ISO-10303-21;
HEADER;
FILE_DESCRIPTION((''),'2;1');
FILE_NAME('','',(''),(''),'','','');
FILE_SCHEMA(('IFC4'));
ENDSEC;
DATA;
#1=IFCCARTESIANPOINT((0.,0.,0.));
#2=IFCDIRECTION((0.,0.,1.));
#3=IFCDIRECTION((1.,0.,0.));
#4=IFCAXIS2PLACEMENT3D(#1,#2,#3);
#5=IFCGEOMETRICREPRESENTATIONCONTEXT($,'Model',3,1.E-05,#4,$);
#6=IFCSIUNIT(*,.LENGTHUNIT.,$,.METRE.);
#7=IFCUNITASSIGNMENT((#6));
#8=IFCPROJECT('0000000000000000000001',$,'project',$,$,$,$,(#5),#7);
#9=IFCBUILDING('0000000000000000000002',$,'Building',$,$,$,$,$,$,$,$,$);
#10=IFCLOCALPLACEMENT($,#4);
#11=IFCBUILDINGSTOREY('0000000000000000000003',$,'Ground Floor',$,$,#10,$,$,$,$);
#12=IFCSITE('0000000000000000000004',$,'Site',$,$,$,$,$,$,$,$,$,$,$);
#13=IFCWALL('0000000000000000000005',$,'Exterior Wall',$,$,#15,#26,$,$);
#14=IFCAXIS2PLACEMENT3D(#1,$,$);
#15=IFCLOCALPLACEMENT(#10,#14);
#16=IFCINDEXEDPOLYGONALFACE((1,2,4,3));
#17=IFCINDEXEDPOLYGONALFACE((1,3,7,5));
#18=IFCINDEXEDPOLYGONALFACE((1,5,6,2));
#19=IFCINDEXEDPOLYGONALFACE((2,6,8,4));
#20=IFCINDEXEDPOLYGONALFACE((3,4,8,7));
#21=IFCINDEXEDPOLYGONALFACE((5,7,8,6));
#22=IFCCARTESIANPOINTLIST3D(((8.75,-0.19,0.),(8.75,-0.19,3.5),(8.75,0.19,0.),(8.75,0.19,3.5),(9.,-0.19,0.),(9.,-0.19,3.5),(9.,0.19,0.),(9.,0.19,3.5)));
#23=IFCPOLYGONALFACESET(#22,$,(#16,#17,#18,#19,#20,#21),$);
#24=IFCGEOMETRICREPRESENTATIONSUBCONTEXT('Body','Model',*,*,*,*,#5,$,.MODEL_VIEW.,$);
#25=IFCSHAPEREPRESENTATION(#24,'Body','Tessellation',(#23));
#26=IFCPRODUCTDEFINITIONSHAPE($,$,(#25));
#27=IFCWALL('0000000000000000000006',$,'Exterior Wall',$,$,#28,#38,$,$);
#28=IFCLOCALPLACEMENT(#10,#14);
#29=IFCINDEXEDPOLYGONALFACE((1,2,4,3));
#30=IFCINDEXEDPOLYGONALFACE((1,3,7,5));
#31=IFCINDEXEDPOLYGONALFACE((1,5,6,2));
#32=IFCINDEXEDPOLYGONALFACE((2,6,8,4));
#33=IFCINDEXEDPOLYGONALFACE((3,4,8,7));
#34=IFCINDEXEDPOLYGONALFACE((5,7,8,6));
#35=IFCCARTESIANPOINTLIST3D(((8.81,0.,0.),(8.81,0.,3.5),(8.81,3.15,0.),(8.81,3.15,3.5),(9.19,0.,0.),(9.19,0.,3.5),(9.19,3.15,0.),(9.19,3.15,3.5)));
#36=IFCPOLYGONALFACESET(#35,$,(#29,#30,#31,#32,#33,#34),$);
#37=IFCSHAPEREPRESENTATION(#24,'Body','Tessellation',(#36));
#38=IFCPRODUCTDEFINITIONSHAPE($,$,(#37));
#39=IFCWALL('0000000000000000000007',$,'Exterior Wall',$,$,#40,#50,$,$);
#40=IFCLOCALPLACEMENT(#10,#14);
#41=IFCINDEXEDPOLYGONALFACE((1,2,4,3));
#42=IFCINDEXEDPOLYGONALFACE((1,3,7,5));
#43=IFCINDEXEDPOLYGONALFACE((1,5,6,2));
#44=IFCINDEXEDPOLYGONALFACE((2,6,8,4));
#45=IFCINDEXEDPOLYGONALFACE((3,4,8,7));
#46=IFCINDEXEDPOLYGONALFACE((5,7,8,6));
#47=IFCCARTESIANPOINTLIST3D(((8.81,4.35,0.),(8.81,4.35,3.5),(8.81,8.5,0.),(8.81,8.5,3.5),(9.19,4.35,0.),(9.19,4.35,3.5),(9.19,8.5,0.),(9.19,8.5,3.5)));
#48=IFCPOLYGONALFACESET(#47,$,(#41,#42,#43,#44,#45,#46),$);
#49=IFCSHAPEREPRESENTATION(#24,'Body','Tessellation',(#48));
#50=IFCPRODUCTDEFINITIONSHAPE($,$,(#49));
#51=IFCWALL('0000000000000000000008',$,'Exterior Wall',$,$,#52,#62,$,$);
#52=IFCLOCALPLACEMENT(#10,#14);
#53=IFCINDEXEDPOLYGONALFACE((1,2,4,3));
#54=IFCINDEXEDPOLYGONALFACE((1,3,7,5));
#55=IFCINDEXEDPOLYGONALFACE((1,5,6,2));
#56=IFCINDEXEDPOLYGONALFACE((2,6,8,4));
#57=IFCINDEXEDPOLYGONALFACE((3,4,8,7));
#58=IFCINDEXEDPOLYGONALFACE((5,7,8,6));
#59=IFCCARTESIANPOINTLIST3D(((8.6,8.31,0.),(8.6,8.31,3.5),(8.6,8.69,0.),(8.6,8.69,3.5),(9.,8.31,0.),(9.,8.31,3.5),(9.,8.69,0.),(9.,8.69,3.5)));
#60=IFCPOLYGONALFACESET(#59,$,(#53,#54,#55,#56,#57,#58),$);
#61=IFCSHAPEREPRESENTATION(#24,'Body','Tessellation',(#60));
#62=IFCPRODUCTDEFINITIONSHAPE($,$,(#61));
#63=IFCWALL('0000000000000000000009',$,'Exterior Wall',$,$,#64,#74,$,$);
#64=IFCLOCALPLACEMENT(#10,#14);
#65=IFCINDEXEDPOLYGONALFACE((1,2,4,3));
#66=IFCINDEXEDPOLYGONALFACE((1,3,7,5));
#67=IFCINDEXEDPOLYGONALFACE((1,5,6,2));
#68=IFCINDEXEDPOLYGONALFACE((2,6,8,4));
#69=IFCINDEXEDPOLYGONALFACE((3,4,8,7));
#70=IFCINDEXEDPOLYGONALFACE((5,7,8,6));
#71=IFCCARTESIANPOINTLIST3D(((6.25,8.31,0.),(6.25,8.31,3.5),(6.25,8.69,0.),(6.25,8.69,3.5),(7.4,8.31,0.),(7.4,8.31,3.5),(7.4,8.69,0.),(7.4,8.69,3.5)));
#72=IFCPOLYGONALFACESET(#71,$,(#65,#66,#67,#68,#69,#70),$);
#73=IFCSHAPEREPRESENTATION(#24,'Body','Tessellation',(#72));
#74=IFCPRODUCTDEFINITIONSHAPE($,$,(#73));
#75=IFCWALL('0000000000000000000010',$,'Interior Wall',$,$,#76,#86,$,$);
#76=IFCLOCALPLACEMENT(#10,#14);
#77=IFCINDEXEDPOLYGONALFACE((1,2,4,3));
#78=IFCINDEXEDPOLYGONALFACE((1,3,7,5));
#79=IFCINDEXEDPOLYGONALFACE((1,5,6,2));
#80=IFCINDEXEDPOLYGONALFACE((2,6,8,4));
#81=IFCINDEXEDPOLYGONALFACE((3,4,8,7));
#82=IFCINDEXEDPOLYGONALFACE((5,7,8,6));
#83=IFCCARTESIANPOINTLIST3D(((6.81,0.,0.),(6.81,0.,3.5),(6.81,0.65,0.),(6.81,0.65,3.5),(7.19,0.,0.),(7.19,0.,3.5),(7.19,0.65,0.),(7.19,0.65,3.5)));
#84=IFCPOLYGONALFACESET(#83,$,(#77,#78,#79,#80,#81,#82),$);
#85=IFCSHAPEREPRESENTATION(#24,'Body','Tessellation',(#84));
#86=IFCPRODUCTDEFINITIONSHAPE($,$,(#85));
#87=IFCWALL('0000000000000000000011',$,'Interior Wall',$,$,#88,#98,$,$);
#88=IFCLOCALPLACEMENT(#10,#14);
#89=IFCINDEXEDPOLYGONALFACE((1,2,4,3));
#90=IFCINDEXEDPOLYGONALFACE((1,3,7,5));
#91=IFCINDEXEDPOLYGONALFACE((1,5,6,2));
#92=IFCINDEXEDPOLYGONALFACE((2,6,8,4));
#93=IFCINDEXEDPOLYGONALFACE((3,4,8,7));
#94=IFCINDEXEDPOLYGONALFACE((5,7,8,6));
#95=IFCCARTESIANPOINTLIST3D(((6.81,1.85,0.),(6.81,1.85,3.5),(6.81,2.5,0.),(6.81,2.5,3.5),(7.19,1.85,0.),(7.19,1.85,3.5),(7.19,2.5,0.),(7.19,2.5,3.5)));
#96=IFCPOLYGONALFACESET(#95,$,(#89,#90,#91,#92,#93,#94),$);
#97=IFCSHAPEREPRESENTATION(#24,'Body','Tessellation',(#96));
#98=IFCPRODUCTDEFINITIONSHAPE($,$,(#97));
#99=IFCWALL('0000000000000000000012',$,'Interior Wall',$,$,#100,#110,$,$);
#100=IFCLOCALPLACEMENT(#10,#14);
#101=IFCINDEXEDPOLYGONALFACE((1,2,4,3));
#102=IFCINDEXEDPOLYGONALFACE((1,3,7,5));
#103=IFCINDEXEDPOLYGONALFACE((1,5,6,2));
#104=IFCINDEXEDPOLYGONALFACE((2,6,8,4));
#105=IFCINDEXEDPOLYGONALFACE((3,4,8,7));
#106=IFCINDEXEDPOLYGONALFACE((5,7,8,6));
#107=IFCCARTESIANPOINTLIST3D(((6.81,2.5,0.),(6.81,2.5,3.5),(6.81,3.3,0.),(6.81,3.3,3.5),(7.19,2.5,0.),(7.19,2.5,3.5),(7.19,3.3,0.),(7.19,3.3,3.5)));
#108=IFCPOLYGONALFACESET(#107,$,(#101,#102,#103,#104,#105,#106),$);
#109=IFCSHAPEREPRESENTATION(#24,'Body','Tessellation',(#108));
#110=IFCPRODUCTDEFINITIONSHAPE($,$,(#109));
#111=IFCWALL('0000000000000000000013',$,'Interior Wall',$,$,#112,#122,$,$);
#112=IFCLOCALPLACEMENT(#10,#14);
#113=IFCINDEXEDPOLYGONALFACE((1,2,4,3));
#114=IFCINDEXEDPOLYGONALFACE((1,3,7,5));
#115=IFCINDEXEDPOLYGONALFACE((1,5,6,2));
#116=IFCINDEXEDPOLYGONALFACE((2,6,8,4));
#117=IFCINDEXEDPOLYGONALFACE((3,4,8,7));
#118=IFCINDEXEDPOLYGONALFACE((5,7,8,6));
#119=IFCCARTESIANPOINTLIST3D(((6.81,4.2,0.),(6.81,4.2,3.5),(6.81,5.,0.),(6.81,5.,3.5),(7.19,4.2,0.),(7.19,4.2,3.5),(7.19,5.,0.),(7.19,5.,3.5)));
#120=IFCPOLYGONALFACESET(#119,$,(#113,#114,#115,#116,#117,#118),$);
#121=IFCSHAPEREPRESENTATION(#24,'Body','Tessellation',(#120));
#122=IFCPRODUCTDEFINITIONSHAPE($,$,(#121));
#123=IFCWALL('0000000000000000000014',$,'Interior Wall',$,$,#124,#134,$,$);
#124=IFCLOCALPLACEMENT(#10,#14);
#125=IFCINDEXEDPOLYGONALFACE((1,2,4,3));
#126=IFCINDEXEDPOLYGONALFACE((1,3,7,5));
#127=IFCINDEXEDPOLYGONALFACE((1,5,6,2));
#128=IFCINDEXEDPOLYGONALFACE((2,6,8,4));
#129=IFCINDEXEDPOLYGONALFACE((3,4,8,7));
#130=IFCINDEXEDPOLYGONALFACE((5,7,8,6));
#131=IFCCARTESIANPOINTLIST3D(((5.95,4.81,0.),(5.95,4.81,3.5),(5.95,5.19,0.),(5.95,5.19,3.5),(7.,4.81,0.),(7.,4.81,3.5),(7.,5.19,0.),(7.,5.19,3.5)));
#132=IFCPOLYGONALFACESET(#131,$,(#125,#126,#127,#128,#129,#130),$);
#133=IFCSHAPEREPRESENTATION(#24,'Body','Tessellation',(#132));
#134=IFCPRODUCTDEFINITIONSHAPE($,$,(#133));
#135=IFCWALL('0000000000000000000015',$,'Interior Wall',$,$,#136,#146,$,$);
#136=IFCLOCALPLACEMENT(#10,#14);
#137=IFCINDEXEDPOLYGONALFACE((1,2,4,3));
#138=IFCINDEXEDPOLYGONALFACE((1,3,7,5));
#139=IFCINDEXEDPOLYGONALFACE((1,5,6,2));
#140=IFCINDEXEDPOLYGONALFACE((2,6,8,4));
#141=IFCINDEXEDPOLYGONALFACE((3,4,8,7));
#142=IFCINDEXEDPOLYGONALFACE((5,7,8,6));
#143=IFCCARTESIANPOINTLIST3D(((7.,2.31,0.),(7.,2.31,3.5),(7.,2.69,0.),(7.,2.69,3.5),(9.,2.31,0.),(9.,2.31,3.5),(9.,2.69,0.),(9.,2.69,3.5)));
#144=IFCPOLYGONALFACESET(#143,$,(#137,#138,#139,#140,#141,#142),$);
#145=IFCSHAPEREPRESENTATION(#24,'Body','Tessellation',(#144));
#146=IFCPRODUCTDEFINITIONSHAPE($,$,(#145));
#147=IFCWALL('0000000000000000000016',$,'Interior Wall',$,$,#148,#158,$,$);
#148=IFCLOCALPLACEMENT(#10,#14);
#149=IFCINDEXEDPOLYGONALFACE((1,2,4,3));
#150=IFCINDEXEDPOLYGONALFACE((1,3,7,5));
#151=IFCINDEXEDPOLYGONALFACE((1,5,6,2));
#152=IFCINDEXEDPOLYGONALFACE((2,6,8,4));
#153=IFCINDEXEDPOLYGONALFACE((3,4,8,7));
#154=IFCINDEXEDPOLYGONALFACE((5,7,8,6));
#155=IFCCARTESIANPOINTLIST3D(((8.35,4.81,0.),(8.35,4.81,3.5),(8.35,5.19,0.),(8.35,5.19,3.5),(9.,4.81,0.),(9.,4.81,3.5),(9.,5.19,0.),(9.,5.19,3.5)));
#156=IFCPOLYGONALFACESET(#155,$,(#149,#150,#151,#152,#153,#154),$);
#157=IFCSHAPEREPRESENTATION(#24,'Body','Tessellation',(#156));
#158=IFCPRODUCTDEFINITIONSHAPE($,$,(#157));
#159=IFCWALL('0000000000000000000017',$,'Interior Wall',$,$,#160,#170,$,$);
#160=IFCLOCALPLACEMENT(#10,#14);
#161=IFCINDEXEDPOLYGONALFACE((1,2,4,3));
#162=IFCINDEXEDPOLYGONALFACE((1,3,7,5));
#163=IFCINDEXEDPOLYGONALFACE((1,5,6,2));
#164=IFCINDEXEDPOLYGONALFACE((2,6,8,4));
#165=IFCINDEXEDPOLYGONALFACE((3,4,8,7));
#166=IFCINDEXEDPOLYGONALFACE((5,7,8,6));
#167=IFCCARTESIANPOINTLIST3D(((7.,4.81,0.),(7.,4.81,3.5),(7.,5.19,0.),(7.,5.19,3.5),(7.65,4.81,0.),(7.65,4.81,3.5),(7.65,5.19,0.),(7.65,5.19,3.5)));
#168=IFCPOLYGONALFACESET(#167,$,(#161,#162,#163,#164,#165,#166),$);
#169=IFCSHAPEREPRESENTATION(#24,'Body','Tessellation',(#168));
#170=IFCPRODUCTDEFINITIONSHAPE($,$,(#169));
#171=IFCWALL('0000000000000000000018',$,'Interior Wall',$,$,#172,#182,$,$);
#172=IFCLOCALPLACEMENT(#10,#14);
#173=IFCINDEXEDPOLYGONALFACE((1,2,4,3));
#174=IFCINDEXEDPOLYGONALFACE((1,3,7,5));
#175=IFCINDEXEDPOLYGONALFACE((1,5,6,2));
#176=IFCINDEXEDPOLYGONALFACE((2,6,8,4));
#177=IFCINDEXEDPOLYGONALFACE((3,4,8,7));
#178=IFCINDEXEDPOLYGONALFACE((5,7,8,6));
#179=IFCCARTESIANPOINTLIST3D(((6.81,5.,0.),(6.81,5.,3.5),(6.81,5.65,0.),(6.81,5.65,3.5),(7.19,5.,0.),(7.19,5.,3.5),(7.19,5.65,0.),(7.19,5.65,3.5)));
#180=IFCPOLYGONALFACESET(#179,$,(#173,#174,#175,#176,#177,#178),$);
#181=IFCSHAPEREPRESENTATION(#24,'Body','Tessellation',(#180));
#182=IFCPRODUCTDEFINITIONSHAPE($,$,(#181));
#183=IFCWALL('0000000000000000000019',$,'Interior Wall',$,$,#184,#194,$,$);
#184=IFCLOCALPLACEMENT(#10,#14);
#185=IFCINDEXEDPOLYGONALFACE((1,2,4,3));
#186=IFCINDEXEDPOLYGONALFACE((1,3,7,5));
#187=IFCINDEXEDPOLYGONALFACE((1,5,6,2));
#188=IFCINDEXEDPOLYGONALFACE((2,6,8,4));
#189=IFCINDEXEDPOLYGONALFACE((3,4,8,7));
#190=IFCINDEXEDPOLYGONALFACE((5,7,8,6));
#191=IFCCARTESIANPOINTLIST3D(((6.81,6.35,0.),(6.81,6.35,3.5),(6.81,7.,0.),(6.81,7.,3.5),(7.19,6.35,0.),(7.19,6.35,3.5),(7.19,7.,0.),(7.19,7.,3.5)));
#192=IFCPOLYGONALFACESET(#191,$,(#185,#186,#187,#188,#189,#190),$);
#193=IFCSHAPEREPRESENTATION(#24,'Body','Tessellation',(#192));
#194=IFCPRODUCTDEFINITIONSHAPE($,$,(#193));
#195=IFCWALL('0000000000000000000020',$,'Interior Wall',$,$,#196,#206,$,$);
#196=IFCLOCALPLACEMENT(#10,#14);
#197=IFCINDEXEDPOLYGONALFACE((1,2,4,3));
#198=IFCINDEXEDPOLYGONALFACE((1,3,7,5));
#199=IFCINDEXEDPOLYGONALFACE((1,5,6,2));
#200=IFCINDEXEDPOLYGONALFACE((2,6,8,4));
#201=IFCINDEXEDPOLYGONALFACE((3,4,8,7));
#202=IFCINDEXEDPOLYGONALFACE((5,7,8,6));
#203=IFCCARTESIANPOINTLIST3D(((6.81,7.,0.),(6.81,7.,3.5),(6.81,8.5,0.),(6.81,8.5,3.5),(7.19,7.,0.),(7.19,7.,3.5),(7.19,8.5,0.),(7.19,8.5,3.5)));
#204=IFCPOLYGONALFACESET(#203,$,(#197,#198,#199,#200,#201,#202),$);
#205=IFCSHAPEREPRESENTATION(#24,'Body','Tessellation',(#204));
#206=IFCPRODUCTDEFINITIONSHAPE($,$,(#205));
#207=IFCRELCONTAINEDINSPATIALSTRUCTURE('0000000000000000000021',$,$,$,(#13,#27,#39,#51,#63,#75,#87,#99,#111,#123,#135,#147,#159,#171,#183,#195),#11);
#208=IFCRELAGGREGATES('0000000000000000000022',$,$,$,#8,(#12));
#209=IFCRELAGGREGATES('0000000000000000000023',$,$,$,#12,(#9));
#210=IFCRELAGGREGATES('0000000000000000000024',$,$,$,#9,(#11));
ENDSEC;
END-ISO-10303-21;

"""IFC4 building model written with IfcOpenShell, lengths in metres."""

from ifc_helpers import new_model, si_unit, frame, origin_with_axes, place, context, subcontext, project, spatial, indexed_curve, outline, extrude, element, save


model = new_model("IFC4")

# Units and contexts
model_context = context("Model", 3, precision=1e-05, world=origin_with_axes())
body_context = subcontext(model_context, "Body", "Model", "MODEL_VIEW")
ifc_project = project(units=[si_unit("LENGTHUNIT", "METRE")], contexts=[model_context])

# Site, building, storey
site = spatial("IfcSite", under=ifc_project, Name="Site")
building = spatial("IfcBuilding", under=site, Name="Building")
storey_placement = place(None, origin_with_axes())
storey = spatial("IfcBuildingStorey", under=building, at=storey_placement, Name="Ground Floor")

# Walls
wall_1_placement = place(storey_placement, frame((8.75, 0.0, 0.0), z_axis=(0.0, 0.0, 1.0), x_axis=(1.0, 0.0, 0.0)))
element("IfcWall", 1, at=wall_1_placement, inside=storey, Name="Exterior Wall", context=body_context, shape_type="SweptSolid", body=[
    extrude(outline(indexed_curve([(0.0, 0.0), (0.0, 0.38), (0.25, 0.38), (0.25, 0.0), (0.0, 0.0)], self_intersect=False)), frame((0.0, -0.19, 0.0), z_axis=(0.0, 0.0, 1.0), x_axis=(1.0, 0.0, 0.0)), (0.0, 0.0, 1.0), 3.5),
])
wall_2_placement = place(storey_placement, frame((9.0, 0.0, 0.0), z_axis=(0.0, 0.0, 1.0), x_axis=(0.0, 1.0, 0.0)))
element("IfcWall", 2, at=wall_2_placement, inside=storey, Name="Exterior Wall", context=body_context, shape_type="SweptSolid", body=[
    extrude(outline(indexed_curve([(0.0, 0.0), (0.0, 0.38), (3.15, 0.38), (3.15, 0.0), (0.0, 0.0)], self_intersect=False)), frame((0.0, -0.19, 0.0), z_axis=(0.0, 0.0, 1.0), x_axis=(1.0, 0.0, 0.0)), (0.0, 0.0, 1.0), 3.5),
])
wall_3_placement = place(storey_placement, frame((9.0, 4.35, 0.0), z_axis=(0.0, 0.0, 1.0), x_axis=(0.0, 1.0, 0.0)))
element("IfcWall", 3, at=wall_3_placement, inside=storey, Name="Exterior Wall", context=body_context, shape_type="SweptSolid", body=[
    extrude(outline(indexed_curve([(0.0, 0.0), (0.0, 0.38), (4.15, 0.38), (4.15, 0.0), (0.0, 0.0)], self_intersect=False)), frame((0.0, -0.19, 0.0), z_axis=(0.0, 0.0, 1.0), x_axis=(1.0, 0.0, 0.0)), (0.0, 0.0, 1.0), 3.5),
])
wall_4_placement = place(storey_placement, frame((9.0, 8.5, 0.0), z_axis=(0.0, 0.0, 1.0), x_axis=(-1.0, 0.0, 0.0)))
element("IfcWall", 4, at=wall_4_placement, inside=storey, Name="Exterior Wall", context=body_context, shape_type="SweptSolid", body=[
    extrude(outline(indexed_curve([(0.0, 0.0), (0.0, 0.38), (0.4, 0.38), (0.4, 0.0), (0.0, 0.0)], self_intersect=False)), frame((0.0, -0.19, 0.0), z_axis=(0.0, 0.0, 1.0), x_axis=(1.0, 0.0, 0.0)), (0.0, 0.0, 1.0), 3.5),
])
wall_5_placement = place(storey_placement, frame((7.4, 8.5, 0.0), z_axis=(0.0, 0.0, 1.0), x_axis=(-1.0, 0.0, 0.0)))
element("IfcWall", 5, at=wall_5_placement, inside=storey, Name="Exterior Wall", context=body_context, shape_type="SweptSolid", body=[
    extrude(outline(indexed_curve([(0.0, 0.0), (0.0, 0.38), (1.15, 0.38), (1.15, 0.0), (0.0, 0.0)], self_intersect=False)), frame((0.0, -0.19, 0.0), z_axis=(0.0, 0.0, 1.0), x_axis=(1.0, 0.0, 0.0)), (0.0, 0.0, 1.0), 3.5),
])
wall_6_placement = place(storey_placement, frame((7.0, 0.0, 0.0), z_axis=(0.0, 0.0, 1.0), x_axis=(0.0, 1.0, 0.0)))
element("IfcWall", 6, at=wall_6_placement, inside=storey, Name="Interior Wall", context=body_context, shape_type="SweptSolid", body=[
    extrude(outline(indexed_curve([(0.0, 0.0), (0.0, 0.38), (0.65, 0.38), (0.65, 0.0), (0.0, 0.0)], self_intersect=False)), frame((0.0, -0.19, 0.0), z_axis=(0.0, 0.0, 1.0), x_axis=(1.0, 0.0, 0.0)), (0.0, 0.0, 1.0), 3.5),
])
wall_7_placement = place(storey_placement, frame((7.0, 1.85, 0.0), z_axis=(0.0, 0.0, 1.0), x_axis=(0.0, 1.0, 0.0)))
element("IfcWall", 7, at=wall_7_placement, inside=storey, Name="Interior Wall", context=body_context, shape_type="SweptSolid", body=[
    extrude(outline(indexed_curve([(0.0, 0.0), (0.0, 0.38), (0.65, 0.38), (0.65, 0.0), (0.0, 0.0)], self_intersect=False)), frame((0.0, -0.19, 0.0), z_axis=(0.0, 0.0, 1.0), x_axis=(1.0, 0.0, 0.0)), (0.0, 0.0, 1.0), 3.5),
])
for number, where, z_axis, x_axis, name in (
    (8, (7.0, 2.5, 0.0), (0.0, 0.0, 1.0), (0.0, 1.0, 0.0), "Interior Wall"),
    (9, (7.0, 4.2, 0.0), (0.0, 0.0, 1.0), (0.0, 1.0, 0.0), "Interior Wall"),
):
    element("IfcWall", number, at=place(storey_placement, frame(where, z_axis=z_axis, x_axis=x_axis)), inside=storey, Name=name, context=body_context, shape_type="SweptSolid", body=[
        extrude(outline(indexed_curve([(0.0, 0.0), (0.0, 0.38), (0.8, 0.38), (0.8, 0.0), (0.0, 0.0)], self_intersect=False)), frame((0.0, -0.19, 0.0), z_axis=(0.0, 0.0, 1.0), x_axis=(1.0, 0.0, 0.0)), (0.0, 0.0, 1.0), 3.5),
    ])
wall_8_placement = place(storey_placement, frame((7.0, 5.0, 0.0), z_axis=(0.0, 0.0, 1.0), x_axis=(-1.0, 0.0, 0.0)))
element("IfcWall", 10, at=wall_8_placement, inside=storey, Name="Interior Wall", context=body_context, shape_type="SweptSolid", body=[
    extrude(outline(indexed_curve([(0.0, 0.0), (0.0, 0.38), (1.05, 0.38), (1.05, 0.0), (0.0, 0.0)], self_intersect=False)), frame((0.0, -0.19, 0.0), z_axis=(0.0, 0.0, 1.0), x_axis=(1.0, 0.0, 0.0)), (0.0, 0.0, 1.0), 3.5),
])
wall_9_placement = place(storey_placement, frame((9.0, 2.5, 0.0), z_axis=(0.0, 0.0, 1.0), x_axis=(-1.0, 0.0, 0.0)))
element("IfcWall", 11, at=wall_9_placement, inside=storey, Name="Interior Wall", context=body_context, shape_type="SweptSolid", body=[
    extrude(outline(indexed_curve([(0.0, 0.0), (0.0, 0.38), (2.0, 0.38), (2.0, 0.0), (0.0, 0.0)], self_intersect=False)), frame((0.0, -0.19, 0.0), z_axis=(0.0, 0.0, 1.0), x_axis=(1.0, 0.0, 0.0)), (0.0, 0.0, 1.0), 3.5),
])
for number, where, z_axis, x_axis, name in (
    (12, (9.0, 5.0, 0.0), (0.0, 0.0, 1.0), (-1.0, 0.0, 0.0), "Interior Wall"),
    (13, (7.65, 5.0, 0.0), (0.0, 0.0, 1.0), (-1.0, 0.0, 0.0), "Interior Wall"),
    (14, (7.0, 5.0, 0.0), (0.0, 0.0, 1.0), (0.0, 1.0, 0.0), "Interior Wall"),
    (15, (7.0, 6.35, 0.0), (0.0, 0.0, 1.0), (0.0, 1.0, 0.0), "Interior Wall"),
):
    element("IfcWall", number, at=place(storey_placement, frame(where, z_axis=z_axis, x_axis=x_axis)), inside=storey, Name=name, context=body_context, shape_type="SweptSolid", body=[
        extrude(outline(indexed_curve([(0.0, 0.0), (0.0, 0.38), (0.65, 0.38), (0.65, 0.0), (0.0, 0.0)], self_intersect=False)), frame((0.0, -0.19, 0.0), z_axis=(0.0, 0.0, 1.0), x_axis=(1.0, 0.0, 0.0)), (0.0, 0.0, 1.0), 3.5),
    ])
wall_10_placement = place(storey_placement, frame((7.0, 7.0, 0.0), z_axis=(0.0, 0.0, 1.0), x_axis=(0.0, 1.0, 0.0)))
element("IfcWall", 16, at=wall_10_placement, inside=storey, Name="Interior Wall", context=body_context, shape_type="SweptSolid", body=[
    extrude(outline(indexed_curve([(0.0, 0.0), (0.0, 0.38), (1.5, 0.38), (1.5, 0.0), (0.0, 0.0)], self_intersect=False)), frame((0.0, -0.19, 0.0), z_axis=(0.0, 0.0, 1.0), x_axis=(1.0, 0.0, 0.0)), (0.0, 0.0, 1.0), 3.5),
])

save(model, "model.ifc")
